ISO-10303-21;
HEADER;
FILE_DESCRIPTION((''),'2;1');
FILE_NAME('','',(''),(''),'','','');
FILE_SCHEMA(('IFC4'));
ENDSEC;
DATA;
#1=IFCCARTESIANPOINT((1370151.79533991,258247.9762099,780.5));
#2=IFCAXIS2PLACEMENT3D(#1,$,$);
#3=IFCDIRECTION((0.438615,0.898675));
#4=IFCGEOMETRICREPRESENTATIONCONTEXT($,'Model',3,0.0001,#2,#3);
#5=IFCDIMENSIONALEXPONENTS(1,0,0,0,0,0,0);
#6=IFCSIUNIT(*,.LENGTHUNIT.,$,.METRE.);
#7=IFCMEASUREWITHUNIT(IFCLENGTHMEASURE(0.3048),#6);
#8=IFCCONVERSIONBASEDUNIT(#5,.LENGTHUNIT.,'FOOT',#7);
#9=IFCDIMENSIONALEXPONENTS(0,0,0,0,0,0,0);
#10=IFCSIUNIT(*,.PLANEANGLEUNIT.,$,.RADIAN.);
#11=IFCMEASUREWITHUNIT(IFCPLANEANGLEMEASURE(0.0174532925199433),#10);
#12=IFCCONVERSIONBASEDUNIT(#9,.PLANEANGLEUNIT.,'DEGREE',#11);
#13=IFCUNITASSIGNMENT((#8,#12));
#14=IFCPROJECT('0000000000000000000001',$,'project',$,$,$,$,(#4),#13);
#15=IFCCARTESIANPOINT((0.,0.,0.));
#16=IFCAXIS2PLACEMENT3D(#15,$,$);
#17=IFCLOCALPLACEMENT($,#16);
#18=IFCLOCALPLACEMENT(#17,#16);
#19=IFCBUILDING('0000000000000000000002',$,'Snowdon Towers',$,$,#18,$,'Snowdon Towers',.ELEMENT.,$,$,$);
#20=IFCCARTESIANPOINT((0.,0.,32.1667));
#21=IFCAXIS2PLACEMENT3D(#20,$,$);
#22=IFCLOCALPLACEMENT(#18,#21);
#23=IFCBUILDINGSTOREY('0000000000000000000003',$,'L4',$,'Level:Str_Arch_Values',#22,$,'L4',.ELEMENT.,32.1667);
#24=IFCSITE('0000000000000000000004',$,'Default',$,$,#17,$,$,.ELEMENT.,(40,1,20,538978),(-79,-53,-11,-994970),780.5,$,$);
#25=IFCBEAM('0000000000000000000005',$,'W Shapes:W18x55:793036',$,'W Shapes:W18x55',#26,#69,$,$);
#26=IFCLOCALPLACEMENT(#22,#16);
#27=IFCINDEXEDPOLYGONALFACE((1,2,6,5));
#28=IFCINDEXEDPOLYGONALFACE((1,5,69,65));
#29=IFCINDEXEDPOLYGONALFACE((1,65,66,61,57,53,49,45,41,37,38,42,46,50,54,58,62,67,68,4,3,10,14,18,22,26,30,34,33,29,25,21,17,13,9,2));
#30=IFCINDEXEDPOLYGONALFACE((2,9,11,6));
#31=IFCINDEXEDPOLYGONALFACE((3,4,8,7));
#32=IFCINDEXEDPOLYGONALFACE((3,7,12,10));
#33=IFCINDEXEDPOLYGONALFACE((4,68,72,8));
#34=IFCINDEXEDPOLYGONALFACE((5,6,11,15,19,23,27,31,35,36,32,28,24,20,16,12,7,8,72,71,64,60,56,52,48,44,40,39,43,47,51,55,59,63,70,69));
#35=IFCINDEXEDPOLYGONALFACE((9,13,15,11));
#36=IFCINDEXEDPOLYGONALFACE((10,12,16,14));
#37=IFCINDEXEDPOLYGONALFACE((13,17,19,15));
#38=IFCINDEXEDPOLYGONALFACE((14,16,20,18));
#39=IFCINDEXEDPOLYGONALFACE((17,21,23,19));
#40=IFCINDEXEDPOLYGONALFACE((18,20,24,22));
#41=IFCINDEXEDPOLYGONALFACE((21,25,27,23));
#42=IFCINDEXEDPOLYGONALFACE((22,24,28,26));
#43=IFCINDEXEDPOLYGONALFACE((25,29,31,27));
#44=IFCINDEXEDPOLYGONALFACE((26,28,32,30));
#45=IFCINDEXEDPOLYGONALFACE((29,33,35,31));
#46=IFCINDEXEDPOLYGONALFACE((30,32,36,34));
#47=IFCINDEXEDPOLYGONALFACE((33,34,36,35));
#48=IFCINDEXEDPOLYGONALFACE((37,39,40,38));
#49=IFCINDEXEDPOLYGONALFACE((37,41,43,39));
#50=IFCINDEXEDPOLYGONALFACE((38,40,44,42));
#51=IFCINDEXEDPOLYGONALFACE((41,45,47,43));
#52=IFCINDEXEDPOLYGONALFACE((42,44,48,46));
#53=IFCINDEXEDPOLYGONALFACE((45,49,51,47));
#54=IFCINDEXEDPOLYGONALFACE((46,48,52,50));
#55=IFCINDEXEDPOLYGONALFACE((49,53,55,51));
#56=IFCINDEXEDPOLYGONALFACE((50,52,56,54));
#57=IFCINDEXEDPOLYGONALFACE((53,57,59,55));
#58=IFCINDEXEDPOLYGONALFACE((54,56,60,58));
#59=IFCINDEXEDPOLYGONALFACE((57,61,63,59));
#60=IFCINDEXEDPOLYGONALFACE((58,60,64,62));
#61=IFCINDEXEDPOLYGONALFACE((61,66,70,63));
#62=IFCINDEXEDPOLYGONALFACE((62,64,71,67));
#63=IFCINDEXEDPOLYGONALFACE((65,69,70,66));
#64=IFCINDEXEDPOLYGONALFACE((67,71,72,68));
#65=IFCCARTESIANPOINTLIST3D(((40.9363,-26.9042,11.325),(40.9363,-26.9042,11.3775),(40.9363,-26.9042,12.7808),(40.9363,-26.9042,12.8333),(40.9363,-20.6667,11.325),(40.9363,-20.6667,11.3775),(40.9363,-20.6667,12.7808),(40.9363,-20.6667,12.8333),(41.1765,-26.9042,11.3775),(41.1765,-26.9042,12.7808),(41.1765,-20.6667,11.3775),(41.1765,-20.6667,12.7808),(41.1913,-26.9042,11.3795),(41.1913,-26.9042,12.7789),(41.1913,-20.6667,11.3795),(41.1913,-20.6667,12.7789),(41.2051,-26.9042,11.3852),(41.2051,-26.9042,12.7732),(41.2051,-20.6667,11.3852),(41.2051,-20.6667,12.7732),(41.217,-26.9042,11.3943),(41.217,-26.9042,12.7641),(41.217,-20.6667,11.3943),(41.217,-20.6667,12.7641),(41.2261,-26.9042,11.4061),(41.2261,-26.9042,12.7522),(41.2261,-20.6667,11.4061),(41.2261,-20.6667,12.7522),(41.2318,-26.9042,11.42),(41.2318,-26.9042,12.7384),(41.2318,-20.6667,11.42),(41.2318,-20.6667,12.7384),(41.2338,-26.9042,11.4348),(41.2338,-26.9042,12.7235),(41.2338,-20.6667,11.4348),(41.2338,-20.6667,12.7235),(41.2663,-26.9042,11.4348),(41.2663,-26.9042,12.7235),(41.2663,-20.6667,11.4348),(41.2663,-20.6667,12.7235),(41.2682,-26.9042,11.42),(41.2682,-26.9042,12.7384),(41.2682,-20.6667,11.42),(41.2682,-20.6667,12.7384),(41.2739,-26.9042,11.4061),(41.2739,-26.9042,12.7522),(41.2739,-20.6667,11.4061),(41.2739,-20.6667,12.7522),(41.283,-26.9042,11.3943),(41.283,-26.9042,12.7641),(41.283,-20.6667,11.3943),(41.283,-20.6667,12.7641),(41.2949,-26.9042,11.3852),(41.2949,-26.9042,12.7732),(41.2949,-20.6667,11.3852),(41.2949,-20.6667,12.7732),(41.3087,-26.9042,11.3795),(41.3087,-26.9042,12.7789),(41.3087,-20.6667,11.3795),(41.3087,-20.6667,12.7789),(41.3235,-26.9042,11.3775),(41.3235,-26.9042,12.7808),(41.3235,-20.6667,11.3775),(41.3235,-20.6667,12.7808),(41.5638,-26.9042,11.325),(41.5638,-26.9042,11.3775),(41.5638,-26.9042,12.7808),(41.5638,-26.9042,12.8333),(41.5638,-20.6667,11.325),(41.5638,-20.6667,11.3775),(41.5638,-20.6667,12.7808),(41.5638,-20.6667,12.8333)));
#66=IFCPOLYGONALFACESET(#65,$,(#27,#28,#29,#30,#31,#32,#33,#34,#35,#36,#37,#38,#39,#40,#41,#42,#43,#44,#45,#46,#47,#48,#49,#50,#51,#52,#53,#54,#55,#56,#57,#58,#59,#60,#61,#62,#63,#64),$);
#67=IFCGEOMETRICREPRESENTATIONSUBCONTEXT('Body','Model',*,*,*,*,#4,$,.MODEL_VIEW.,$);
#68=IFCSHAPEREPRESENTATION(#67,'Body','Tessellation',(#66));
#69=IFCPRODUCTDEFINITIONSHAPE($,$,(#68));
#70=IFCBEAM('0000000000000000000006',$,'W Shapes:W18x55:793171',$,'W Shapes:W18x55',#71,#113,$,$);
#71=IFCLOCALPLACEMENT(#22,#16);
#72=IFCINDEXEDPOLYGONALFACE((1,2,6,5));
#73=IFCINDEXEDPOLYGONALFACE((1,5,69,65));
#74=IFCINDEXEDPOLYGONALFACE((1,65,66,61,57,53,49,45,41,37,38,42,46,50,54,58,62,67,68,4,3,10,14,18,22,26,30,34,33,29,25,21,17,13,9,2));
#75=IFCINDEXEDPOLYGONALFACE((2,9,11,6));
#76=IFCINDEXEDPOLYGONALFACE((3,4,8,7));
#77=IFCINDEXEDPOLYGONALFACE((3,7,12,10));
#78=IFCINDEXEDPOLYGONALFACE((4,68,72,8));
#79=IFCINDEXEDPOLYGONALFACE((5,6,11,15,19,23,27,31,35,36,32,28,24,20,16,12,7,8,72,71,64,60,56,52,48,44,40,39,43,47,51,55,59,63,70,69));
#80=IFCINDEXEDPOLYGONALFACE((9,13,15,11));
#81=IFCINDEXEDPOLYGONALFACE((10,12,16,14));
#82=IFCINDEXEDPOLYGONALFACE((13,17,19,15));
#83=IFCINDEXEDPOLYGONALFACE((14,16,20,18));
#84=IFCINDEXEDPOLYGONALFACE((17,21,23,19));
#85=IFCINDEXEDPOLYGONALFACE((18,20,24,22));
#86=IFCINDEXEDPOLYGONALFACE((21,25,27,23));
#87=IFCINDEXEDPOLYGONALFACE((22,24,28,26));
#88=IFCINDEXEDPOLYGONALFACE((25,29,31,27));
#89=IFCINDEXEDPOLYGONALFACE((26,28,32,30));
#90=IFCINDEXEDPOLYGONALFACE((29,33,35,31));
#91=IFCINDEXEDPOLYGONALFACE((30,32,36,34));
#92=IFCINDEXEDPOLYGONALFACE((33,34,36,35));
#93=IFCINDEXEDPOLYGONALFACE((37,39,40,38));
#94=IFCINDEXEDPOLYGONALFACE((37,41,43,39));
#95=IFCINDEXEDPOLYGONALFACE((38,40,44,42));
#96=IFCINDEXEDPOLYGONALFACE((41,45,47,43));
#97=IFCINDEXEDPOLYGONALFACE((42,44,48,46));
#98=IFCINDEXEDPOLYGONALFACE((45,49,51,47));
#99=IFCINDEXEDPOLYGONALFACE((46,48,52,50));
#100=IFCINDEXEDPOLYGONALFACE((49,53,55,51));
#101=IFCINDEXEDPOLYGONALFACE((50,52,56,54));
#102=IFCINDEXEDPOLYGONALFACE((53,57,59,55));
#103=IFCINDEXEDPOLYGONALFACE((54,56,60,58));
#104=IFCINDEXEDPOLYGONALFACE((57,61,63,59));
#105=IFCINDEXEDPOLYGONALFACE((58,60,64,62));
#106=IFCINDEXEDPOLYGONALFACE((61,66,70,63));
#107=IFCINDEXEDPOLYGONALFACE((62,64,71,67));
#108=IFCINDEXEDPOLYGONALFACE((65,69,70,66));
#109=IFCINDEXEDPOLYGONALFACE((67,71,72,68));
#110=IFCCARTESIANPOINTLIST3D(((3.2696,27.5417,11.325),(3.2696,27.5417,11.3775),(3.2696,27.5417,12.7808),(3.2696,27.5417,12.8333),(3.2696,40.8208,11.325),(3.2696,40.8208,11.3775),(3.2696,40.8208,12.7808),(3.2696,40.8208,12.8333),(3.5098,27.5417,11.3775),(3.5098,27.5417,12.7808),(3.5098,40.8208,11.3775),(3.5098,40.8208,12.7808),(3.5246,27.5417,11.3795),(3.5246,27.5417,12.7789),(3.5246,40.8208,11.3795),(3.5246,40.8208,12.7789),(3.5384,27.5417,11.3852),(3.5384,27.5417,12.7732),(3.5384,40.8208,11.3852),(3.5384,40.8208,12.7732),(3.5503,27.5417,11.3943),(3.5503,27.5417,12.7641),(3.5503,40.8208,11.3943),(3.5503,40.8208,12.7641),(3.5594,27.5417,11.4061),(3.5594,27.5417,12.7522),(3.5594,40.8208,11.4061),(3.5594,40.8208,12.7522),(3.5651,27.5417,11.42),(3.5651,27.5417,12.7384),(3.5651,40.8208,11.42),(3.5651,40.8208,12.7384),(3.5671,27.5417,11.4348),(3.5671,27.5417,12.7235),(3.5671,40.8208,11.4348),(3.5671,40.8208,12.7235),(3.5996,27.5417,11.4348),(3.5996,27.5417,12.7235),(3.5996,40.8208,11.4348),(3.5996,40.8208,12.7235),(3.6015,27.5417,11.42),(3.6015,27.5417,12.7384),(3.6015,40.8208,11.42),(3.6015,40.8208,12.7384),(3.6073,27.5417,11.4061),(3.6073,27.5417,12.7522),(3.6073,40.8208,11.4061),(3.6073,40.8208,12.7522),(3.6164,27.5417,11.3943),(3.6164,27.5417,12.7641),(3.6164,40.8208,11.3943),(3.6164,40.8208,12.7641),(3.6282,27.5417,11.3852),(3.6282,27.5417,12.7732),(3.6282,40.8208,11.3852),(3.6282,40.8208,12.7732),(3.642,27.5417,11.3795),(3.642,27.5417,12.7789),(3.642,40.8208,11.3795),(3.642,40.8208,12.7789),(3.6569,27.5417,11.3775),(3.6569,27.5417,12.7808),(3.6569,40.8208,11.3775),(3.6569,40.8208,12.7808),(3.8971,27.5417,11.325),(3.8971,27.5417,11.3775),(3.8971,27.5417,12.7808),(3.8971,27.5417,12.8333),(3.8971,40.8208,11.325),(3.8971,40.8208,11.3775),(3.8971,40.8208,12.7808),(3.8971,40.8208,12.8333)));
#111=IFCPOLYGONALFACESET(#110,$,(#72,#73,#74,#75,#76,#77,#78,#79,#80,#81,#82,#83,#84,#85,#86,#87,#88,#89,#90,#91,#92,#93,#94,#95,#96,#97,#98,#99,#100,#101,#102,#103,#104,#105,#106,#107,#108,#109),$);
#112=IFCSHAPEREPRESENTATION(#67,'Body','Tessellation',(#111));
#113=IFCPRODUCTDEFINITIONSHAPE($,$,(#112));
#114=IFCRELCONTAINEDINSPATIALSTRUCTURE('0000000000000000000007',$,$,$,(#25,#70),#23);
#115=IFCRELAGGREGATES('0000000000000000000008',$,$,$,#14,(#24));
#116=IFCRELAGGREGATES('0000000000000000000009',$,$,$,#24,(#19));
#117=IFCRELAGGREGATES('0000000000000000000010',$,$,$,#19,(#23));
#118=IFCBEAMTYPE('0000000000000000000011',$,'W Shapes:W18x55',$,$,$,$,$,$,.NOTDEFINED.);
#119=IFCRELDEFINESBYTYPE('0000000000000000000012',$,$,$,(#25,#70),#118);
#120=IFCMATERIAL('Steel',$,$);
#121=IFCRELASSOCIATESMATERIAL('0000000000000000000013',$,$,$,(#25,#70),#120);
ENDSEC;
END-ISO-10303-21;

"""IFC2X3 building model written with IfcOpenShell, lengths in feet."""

from ifc_helpers import new_model, entity, si_unit, converted_unit, direction, frame, frame_2d, origin, place, context, subcontext, project, spatial, i_section, extrude, material, type_object, element, save


model = new_model("IFC2X3")

# Units and contexts
model_context = context("Model", 3, precision=0.0001, world=frame((1370151.79533991, 258247.9762099, 780.5)), true_north=direction((0.438615, 0.898675)))
body_context = subcontext(model_context, "Body", "Model", "MODEL_VIEW")
ifc_project = project(units=[converted_unit("LENGTHUNIT", "FOOT", entity("IfcLengthMeasure", 0.3048), si_unit("LENGTHUNIT", "METRE"), dimensions=[1, 0, 0, 0, 0, 0, 0]), converted_unit("PLANEANGLEUNIT", "DEGREE", entity("IfcPlaneAngleMeasure", 0.0174532925199433), si_unit("PLANEANGLEUNIT", "RADIAN"), dimensions=[0, 0, 0, 0, 0, 0, 0])], contexts=[model_context])

# Site, building, storey
site_placement = place(None, origin())
site = spatial("IfcSite", under=ifc_project, at=site_placement, Name="Default", CompositionType="ELEMENT", RefLatitude=(40, 1, 20, 538978), RefLongitude=(-79, -53, -11, -994970), RefElevation=780.5)
building_placement = place(site_placement, origin())
building = spatial("IfcBuilding", under=site, at=building_placement, Name="Snowdon Towers", LongName="Snowdon Towers", CompositionType="ELEMENT")
storey_placement = place(building_placement, frame((0.0, 0.0, 32.1667)))
storey = spatial("IfcBuildingStorey", under=building, at=storey_placement, Name="L4", ObjectType="Level:Str_Arch_Values", LongName="L4", CompositionType="ELEMENT", Elevation=32.1667)

# Beams
ifc_material = material(Name="Steel")
beam_type_1 = type_object("IfcBeamType", Name="W Shapes:W18x55", PredefinedType="NOTDEFINED")
beam_1_placement = place(storey_placement, frame((41.25, -20.125, 12.8333), z_axis=(0.0, 0.0, 1.0), x_axis=(0.0, -1.0, 0.0)))
element("IfcBeam", 1, at=beam_1_placement, inside=storey, type_object=beam_type_1, material=ifc_material, Name="W Shapes:W18x55:793036", ObjectType="W Shapes:W18x55", context=body_context, shape_type="SweptSolid", body=[
    extrude(i_section(OverallWidth=0.6275, OverallDepth=1.5083, WebThickness=0.0325, FlangeThickness=0.0525, FilletRadius=0.0573, at=frame_2d((0.0, 0.0), x_axis=(0.0, 1.0))), frame((0.5417, 0.0, -0.7542), z_axis=(1.0, 0.0, 0.0), x_axis=(0.0, 0.0, -1.0)), (0.0, 0.0, 1.0), 6.2375),
])
beam_2_placement = place(storey_placement, frame((3.5833, 41.625, 12.8333), z_axis=(0.0, 0.0, 1.0), x_axis=(0.0, -1.0, 0.0)))
element("IfcBeam", 2, at=beam_2_placement, inside=storey, type_object=beam_type_1, material=ifc_material, Name="W Shapes:W18x55:793171", ObjectType="W Shapes:W18x55", context=body_context, shape_type="SweptSolid", body=[
    extrude(i_section(OverallWidth=0.6275, OverallDepth=1.5083, WebThickness=0.0325, FlangeThickness=0.0525, FilletRadius=0.0573, at=frame_2d((0.0, 0.0), x_axis=(0.0, 1.0))), frame((0.8042, 0.0, -0.7542), z_axis=(1.0, 0.0, 0.0), x_axis=(0.0, 0.0, -1.0)), (0.0, 0.0, 1.0), 13.2792),
])

save(model, "model.ifc")
